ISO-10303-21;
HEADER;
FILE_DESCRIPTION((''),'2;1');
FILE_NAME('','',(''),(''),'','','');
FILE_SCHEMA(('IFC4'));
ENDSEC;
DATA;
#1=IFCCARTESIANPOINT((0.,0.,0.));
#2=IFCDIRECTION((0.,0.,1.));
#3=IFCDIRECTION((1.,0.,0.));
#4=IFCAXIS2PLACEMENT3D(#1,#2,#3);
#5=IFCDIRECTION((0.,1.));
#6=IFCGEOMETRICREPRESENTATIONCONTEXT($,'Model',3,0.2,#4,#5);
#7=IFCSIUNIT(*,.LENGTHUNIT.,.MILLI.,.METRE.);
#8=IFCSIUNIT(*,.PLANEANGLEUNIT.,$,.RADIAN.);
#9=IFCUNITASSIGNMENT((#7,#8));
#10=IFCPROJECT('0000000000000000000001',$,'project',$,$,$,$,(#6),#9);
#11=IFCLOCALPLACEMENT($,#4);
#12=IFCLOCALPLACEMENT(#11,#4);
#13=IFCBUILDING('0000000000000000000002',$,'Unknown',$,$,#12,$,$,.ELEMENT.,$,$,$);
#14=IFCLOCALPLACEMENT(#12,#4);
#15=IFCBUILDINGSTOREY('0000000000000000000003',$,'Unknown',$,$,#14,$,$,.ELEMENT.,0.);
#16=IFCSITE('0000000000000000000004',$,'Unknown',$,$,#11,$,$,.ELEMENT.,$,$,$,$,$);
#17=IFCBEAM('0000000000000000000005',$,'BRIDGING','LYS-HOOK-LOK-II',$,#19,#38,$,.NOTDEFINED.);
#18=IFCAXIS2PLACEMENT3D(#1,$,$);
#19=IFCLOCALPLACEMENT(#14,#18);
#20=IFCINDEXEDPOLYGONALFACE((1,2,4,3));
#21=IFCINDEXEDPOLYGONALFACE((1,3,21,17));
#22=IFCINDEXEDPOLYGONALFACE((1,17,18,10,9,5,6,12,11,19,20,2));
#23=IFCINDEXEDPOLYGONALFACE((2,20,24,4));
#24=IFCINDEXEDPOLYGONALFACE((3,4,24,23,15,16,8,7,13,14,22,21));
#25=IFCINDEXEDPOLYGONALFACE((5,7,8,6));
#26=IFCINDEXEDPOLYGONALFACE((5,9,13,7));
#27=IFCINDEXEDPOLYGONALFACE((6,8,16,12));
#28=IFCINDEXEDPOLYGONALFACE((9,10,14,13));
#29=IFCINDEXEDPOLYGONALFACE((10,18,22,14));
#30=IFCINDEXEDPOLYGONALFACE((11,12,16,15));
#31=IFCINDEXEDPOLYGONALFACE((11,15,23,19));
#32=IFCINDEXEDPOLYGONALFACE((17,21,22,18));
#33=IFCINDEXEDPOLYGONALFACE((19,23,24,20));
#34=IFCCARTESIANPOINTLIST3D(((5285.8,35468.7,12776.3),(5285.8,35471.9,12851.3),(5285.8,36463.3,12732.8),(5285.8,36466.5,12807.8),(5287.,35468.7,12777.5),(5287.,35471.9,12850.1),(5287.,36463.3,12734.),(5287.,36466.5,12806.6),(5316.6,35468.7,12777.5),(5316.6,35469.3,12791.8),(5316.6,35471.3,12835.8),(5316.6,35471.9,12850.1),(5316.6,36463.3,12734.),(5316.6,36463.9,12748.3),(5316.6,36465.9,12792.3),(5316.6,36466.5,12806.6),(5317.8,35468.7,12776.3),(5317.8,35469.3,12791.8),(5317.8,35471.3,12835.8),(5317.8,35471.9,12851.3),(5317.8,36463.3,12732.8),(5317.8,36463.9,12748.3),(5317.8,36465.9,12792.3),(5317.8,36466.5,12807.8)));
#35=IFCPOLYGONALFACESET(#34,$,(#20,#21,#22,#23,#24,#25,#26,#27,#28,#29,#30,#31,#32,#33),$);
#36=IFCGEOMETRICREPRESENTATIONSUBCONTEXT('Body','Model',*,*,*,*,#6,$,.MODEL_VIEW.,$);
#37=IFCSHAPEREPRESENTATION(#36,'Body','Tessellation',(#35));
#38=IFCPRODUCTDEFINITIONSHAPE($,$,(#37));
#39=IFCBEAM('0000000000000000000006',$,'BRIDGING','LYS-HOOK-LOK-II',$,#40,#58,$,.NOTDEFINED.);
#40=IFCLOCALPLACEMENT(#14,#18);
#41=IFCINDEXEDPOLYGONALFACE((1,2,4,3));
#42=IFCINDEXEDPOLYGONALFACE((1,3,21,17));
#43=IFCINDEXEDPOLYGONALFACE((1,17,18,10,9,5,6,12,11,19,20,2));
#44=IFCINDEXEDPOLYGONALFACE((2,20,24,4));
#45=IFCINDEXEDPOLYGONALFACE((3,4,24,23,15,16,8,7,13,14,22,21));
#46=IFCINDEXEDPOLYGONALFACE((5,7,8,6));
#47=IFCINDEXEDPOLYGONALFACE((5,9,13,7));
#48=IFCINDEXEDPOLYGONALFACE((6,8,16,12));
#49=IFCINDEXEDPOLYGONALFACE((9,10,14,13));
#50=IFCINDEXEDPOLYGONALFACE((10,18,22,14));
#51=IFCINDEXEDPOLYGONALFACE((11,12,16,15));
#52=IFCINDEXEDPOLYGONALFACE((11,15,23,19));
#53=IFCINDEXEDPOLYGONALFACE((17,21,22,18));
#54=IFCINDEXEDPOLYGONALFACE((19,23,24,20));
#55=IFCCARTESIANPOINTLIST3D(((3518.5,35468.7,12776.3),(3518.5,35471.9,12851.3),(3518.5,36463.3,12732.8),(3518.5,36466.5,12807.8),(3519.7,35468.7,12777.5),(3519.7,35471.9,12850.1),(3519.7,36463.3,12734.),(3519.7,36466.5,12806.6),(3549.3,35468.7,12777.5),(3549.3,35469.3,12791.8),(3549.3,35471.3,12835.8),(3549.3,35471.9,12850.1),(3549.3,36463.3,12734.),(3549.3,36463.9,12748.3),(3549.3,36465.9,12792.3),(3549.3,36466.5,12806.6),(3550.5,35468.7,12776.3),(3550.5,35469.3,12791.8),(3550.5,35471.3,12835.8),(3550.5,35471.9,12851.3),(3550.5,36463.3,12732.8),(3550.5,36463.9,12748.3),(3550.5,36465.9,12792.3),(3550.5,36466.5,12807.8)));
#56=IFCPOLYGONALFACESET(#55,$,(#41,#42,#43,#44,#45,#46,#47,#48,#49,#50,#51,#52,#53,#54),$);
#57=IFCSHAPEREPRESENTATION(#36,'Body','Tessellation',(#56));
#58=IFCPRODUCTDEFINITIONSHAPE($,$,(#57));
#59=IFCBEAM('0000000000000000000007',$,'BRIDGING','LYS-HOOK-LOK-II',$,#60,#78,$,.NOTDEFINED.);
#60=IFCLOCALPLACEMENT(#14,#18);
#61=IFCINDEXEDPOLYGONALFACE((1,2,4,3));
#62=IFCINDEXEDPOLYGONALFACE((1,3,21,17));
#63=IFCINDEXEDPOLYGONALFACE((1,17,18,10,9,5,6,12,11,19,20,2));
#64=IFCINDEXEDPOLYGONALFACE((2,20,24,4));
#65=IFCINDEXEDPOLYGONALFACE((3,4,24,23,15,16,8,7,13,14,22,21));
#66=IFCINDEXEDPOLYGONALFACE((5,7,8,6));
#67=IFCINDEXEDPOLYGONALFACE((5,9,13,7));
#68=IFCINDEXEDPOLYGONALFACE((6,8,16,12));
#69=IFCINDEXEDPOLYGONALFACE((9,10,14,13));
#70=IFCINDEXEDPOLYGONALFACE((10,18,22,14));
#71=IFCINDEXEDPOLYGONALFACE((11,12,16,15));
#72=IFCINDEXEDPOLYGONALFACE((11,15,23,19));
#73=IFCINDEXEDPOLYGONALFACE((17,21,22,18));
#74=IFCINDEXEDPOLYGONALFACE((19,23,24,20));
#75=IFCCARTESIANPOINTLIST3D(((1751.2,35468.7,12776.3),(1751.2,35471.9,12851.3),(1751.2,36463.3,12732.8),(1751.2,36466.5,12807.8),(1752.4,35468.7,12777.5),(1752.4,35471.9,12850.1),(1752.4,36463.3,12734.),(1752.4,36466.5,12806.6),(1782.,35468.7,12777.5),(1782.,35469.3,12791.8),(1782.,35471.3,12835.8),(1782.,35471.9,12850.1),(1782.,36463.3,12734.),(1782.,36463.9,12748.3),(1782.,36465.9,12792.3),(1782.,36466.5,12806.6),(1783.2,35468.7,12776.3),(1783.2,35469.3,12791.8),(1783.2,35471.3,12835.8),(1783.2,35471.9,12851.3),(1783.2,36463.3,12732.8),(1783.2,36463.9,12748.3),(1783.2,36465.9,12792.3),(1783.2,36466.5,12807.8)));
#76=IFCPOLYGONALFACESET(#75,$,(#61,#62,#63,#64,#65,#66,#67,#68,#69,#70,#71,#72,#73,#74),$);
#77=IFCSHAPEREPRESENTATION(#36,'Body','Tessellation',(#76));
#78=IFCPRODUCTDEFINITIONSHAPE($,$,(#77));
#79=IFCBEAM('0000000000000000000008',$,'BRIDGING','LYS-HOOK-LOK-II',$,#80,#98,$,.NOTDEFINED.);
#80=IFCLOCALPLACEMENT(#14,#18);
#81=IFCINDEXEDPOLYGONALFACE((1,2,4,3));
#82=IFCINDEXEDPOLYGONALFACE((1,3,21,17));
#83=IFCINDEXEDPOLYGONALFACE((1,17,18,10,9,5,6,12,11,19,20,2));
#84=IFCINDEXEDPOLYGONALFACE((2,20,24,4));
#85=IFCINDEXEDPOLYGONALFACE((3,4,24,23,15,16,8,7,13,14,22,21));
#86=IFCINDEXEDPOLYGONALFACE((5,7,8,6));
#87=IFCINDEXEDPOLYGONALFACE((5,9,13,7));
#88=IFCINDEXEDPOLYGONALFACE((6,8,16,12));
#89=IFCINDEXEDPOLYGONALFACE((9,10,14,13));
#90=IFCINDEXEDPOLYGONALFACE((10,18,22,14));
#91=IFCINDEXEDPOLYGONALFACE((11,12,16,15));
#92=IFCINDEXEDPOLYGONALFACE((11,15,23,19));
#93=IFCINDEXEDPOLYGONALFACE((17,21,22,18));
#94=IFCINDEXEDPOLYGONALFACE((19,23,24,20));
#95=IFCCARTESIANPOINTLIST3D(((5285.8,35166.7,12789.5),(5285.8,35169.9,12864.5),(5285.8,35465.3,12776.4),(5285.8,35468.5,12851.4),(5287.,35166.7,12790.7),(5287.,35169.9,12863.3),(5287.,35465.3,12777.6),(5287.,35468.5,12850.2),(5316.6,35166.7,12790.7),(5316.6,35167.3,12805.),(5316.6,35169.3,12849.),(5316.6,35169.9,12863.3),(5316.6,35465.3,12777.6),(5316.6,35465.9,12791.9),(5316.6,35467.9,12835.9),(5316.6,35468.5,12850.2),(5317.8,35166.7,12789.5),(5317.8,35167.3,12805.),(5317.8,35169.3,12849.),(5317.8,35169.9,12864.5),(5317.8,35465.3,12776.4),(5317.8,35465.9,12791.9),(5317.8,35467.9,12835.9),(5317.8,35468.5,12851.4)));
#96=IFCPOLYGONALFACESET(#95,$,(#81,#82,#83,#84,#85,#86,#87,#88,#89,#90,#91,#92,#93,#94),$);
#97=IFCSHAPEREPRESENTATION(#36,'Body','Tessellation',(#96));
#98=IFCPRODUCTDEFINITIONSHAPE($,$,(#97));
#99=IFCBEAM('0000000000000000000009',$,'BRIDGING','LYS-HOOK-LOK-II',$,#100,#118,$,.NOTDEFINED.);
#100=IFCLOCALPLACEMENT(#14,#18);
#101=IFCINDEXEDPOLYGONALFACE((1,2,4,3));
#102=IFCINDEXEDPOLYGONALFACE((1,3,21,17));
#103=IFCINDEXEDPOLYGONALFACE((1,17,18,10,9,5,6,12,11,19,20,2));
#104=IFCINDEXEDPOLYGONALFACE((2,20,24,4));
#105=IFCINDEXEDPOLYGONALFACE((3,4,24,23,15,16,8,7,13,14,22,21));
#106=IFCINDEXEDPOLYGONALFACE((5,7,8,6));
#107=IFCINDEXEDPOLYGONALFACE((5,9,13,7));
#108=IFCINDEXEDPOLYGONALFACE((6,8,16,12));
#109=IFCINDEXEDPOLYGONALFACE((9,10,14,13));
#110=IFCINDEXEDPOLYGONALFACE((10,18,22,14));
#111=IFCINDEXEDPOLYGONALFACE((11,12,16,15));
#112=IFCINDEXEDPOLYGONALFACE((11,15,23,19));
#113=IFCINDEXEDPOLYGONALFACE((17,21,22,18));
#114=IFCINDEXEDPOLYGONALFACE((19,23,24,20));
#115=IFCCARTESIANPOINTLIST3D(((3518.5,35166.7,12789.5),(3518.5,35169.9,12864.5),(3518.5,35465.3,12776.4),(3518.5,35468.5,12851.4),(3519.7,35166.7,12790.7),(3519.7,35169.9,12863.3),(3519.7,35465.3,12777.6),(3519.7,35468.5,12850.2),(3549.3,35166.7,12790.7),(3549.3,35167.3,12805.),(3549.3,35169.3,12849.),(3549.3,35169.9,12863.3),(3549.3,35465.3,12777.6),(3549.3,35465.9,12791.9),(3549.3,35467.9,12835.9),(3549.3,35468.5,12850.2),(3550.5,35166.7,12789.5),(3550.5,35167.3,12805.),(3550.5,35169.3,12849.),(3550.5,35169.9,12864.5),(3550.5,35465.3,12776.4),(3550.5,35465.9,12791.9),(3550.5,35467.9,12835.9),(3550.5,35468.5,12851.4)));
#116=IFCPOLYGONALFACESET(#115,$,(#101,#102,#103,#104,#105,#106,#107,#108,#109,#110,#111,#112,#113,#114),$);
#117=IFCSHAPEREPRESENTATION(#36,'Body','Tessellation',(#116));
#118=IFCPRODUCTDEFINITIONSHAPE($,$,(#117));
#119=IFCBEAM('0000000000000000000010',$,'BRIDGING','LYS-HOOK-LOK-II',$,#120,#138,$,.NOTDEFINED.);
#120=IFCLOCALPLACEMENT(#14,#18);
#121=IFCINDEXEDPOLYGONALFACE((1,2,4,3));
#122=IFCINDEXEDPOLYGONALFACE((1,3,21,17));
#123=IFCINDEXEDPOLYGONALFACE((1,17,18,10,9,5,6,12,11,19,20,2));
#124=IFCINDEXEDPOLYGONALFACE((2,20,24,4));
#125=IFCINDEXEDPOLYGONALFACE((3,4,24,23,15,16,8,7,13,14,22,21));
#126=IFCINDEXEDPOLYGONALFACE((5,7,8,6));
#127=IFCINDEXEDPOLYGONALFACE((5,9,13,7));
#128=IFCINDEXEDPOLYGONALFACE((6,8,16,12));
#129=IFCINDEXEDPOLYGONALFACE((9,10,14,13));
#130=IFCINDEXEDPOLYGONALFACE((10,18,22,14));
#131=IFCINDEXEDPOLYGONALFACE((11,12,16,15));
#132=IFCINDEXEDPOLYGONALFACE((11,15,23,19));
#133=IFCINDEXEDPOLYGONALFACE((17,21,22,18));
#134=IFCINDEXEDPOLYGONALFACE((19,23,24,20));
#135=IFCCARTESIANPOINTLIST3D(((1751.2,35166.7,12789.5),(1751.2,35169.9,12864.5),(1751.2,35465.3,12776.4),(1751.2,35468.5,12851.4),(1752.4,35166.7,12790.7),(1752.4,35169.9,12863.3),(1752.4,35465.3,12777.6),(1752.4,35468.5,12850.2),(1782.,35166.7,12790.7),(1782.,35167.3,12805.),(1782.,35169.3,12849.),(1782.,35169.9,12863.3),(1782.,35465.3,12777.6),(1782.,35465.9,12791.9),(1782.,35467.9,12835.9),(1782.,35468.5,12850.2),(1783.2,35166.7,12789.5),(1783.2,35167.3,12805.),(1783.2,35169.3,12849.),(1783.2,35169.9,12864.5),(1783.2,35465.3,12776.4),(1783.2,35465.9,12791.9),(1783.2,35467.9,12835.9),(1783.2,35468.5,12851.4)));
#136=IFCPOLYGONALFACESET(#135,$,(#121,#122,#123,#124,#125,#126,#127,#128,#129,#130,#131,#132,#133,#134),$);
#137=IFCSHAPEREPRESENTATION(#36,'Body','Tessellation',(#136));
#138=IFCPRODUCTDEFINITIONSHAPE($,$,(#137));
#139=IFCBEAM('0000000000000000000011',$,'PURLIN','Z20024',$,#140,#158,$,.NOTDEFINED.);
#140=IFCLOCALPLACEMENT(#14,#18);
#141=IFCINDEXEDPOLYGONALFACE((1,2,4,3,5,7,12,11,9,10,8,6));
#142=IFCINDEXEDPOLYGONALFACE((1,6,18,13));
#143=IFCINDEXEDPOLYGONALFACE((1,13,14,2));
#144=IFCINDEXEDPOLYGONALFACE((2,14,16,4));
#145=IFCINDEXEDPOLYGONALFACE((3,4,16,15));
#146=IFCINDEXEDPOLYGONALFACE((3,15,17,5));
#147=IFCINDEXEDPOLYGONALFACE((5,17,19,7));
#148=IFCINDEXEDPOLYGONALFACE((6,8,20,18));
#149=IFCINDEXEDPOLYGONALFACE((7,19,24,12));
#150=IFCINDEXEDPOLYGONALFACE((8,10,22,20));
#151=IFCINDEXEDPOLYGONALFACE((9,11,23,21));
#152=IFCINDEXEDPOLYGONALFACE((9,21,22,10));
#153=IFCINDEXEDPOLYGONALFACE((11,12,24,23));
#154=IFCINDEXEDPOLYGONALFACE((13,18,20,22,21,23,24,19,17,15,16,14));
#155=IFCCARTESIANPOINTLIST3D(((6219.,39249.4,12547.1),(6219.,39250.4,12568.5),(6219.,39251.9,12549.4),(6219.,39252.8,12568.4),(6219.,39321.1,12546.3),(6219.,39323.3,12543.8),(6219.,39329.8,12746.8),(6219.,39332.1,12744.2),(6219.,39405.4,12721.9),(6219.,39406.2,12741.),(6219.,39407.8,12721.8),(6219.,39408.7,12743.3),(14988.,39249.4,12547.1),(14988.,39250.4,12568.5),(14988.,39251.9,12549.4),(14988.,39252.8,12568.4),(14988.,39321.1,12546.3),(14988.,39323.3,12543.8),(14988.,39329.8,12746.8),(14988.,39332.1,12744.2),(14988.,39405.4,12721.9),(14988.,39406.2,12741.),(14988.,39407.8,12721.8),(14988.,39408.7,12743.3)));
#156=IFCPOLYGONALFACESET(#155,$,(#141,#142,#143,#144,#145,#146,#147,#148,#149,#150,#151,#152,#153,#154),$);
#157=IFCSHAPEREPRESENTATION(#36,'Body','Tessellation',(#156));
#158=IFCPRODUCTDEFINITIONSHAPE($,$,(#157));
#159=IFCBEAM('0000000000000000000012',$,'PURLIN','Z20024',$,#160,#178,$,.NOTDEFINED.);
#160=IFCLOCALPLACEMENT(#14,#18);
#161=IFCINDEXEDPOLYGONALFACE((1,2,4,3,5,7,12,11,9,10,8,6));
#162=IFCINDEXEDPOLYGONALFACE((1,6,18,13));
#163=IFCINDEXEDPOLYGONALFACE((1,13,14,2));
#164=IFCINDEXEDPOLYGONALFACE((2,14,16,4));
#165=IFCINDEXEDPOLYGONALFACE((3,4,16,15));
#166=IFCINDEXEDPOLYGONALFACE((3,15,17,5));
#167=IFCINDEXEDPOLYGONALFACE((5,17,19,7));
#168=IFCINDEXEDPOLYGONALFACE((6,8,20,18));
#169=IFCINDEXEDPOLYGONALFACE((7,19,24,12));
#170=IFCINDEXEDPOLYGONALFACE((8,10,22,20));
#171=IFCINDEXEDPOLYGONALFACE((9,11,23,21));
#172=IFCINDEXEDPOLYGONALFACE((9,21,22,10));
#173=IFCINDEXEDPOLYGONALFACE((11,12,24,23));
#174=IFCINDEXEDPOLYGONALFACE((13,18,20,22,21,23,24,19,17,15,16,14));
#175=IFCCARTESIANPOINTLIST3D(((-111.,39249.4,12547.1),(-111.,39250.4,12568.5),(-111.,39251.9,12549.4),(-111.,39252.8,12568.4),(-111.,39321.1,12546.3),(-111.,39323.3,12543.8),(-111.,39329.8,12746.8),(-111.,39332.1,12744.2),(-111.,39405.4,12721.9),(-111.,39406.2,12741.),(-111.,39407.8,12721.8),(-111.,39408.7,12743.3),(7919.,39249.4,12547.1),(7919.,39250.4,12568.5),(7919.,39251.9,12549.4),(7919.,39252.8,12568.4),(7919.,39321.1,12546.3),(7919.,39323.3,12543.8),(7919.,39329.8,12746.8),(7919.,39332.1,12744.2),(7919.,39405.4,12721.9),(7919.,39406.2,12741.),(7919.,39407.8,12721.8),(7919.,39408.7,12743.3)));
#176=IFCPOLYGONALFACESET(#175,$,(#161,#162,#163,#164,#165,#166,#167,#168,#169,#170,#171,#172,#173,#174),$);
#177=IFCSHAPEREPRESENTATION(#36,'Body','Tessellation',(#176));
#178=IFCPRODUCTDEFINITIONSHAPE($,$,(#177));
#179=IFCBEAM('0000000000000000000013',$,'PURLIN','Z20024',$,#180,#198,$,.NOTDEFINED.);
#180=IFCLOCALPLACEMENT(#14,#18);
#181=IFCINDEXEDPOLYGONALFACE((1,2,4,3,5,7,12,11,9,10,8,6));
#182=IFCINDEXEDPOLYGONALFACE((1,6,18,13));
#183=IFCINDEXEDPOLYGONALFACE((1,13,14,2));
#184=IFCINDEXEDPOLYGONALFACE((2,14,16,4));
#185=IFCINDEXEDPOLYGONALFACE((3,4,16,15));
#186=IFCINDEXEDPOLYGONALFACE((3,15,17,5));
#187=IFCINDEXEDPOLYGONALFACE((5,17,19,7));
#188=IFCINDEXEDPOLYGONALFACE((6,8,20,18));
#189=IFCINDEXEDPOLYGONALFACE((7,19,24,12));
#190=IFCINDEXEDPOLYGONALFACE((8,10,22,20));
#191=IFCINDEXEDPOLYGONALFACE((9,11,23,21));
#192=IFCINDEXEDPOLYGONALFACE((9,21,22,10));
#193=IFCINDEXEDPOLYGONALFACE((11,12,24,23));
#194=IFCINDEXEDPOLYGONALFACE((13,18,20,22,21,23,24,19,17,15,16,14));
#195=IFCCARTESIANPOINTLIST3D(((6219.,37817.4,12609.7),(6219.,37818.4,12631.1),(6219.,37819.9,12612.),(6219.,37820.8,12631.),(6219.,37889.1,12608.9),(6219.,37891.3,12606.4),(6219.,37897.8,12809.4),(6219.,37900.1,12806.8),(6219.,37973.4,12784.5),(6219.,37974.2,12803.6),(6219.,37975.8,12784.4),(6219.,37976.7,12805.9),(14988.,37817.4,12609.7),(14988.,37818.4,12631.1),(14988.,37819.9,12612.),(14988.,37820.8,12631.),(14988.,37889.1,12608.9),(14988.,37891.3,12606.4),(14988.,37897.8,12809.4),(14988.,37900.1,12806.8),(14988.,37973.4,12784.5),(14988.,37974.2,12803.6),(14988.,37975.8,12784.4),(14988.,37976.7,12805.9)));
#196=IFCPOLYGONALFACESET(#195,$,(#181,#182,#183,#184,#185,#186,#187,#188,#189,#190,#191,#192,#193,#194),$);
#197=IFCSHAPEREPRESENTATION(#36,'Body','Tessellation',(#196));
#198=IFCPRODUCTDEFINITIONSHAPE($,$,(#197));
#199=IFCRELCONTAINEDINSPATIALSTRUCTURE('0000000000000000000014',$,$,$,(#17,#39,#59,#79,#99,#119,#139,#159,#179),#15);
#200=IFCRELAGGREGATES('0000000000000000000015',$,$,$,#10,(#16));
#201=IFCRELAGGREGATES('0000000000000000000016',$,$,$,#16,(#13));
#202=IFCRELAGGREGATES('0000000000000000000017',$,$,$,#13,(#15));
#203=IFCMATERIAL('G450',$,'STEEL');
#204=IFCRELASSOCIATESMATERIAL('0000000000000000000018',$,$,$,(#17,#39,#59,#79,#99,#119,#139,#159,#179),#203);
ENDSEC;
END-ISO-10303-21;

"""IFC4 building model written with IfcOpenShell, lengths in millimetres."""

from ifc_helpers import new_model, si_unit, direction, frame, origin_with_axes, place, context, subcontext, project, spatial, line, indexed_curve, outline, extrude, material, element, save


model = new_model("IFC4")

# Units and contexts
model_context = context("Model", 3, precision=0.2, world=origin_with_axes(), true_north=direction((0.0, 1.0)))
body_context = subcontext(model_context, "Body", "Model", "MODEL_VIEW")
ifc_project = project(units=[si_unit("LENGTHUNIT", "METRE", prefix="MILLI"), si_unit("PLANEANGLEUNIT", "RADIAN")], contexts=[model_context])

# Site, building, storey
site_placement = place(None, origin_with_axes())
site = spatial("IfcSite", under=ifc_project, at=site_placement, Name="Unknown", CompositionType="ELEMENT")
building_placement = place(site_placement, origin_with_axes())
building = spatial("IfcBuilding", under=site, at=building_placement, Name="Unknown", CompositionType="ELEMENT")
storey_placement = place(building_placement, origin_with_axes())
storey = spatial("IfcBuildingStorey", under=building, at=storey_placement, Name="Unknown", CompositionType="ELEMENT", Elevation=0.0)

# Beams
ifc_material_1 = material(Name="G450", Category="STEEL")
for number, where, z_axis, x_axis, name in (
    (1, (5301.8, 35470.3, 12813.8), (1.0, 0.0, 0.0), (0.0, 0.999045, -0.043694), "BRIDGING"),
    (2, (3534.5, 35470.3, 12813.8), (1.0, 0.0, 0.0), (0.0, 0.999045, -0.043694), "BRIDGING"),
    (3, (1767.2, 35470.3, 12813.8), (1.0, 0.0, 0.0), (0.0, 0.999045, -0.043694), "BRIDGING"),
):
    element("IfcBeam", number, at=place(storey_placement, frame(where, z_axis=z_axis, x_axis=x_axis)), inside=storey, material=ifc_material_1, Name=name, Description="LYS-HOOK-LOK-II", PredefinedType="NOTDEFINED", context=body_context, shape_type="SolidModel", body=[
        extrude(outline(indexed_curve([(16.0, -37.5), (16.0, -22.0), (14.8, -22.0), (14.8, -36.3), (-14.8, -36.3), (-14.8, 36.3), (14.8, 36.3), (14.8, 22.0), (16.0, 22.0), (16.0, 37.5), (-16.0, 37.5), (-16.0, -37.5)], segments=[line(1, 2, 3, 4, 5, 6, 7, 8, 9, 10, 11, 12, 1)])), frame((0.0, 0.0, 0.0), z_axis=(-1.0, 0.0, 0.0), x_axis=(0.0, 0.0, 1.0)), (0.0, 0.0, -1.0), 995.6),
    ])
for number, where, z_axis, x_axis, name in (
    (4, (5301.8, 35168.3, 12827.0), (1.0, 0.0, 0.0), (0.0, 0.999039, -0.043829), "BRIDGING"),
    (5, (3534.5, 35168.3, 12827.0), (1.0, 0.0, 0.0), (0.0, 0.999039, -0.043829), "BRIDGING"),
    (6, (1767.2, 35168.3, 12827.0), (1.0, 0.0, 0.0), (0.0, 0.999039, -0.043829), "BRIDGING"),
):
    element("IfcBeam", number, at=place(storey_placement, frame(where, z_axis=z_axis, x_axis=x_axis)), inside=storey, material=ifc_material_1, Name=name, Description="LYS-HOOK-LOK-II", PredefinedType="NOTDEFINED", context=body_context, shape_type="SolidModel", body=[
        extrude(outline(indexed_curve([(16.0, -37.5), (16.0, -22.0), (14.8, -22.0), (14.8, -36.3), (-14.8, -36.3), (-14.8, 36.3), (14.8, 36.3), (14.8, 22.0), (16.0, 22.0), (16.0, 37.5), (-16.0, 37.5), (-16.0, -37.5)], segments=[line(1, 2, 3, 4, 5, 6, 7, 8, 9, 10, 11, 12, 1)])), frame((0.0, 0.0, 0.0), z_axis=(-1.0, 0.0, 0.0), x_axis=(0.0, 0.0, 1.0)), (0.0, 0.0, -1.0), 298.9),
    ])
beam_1_placement = place(storey_placement, frame((6219.0, 39326.6, 12645.3), z_axis=(0.0, -0.999048, 0.043619), x_axis=(1.0, 0.0, 0.0)))
element("IfcBeam", 7, at=beam_1_placement, inside=storey, material=ifc_material_1, Name="PURLIN", Description="Z20024", PredefinedType="NOTDEFINED", context=body_context, shape_type="SolidModel", body=[
    extrude(outline(indexed_curve([(72.8, -101.5), (72.8, -80.0), (70.4, -80.0), (70.4, -99.1), (1.2, -99.1), (1.2, 101.5), (-77.8, 101.5), (-77.8, 80.0), (-75.4, 80.0), (-75.4, 99.1), (-1.2, 99.1), (-1.2, -101.5)], segments=[line(1, 2, 3, 4, 5, 6, 7, 8, 9, 10, 11, 12, 1)])), frame((0.0, 0.0, 0.0), z_axis=(-1.0, 0.0, 0.0), x_axis=(0.0, 0.0, 1.0)), (0.0, 0.0, -1.0), 8769.0),
])
beam_2_placement = place(storey_placement, frame((-111.0, 39326.6, 12645.3), z_axis=(0.0, -0.999048, 0.043619), x_axis=(1.0, 0.0, 0.0)))
element("IfcBeam", 8, at=beam_2_placement, inside=storey, material=ifc_material_1, Name="PURLIN", Description="Z20024", PredefinedType="NOTDEFINED", context=body_context, shape_type="SolidModel", body=[
    extrude(outline(indexed_curve([(72.8, -101.5), (72.8, -80.0), (70.4, -80.0), (70.4, -99.1), (1.2, -99.1), (1.2, 101.5), (-77.8, 101.5), (-77.8, 80.0), (-75.4, 80.0), (-75.4, 99.1), (-1.2, 99.1), (-1.2, -101.5)], segments=[line(1, 2, 3, 4, 5, 6, 7, 8, 9, 10, 11, 12, 1)])), frame((0.0, 0.0, 0.0), z_axis=(-1.0, 0.0, 0.0), x_axis=(0.0, 0.0, 1.0)), (0.0, 0.0, -1.0), 8030.0),
])
beam_3_placement = place(storey_placement, frame((6219.0, 37894.6, 12707.9), z_axis=(0.0, -0.999048, 0.043619), x_axis=(1.0, 0.0, 0.0)))
element("IfcBeam", 9, at=beam_3_placement, inside=storey, material=ifc_material_1, Name="PURLIN", Description="Z20024", PredefinedType="NOTDEFINED", context=body_context, shape_type="SolidModel", body=[
    extrude(outline(indexed_curve([(72.8, -101.5), (72.8, -80.0), (70.4, -80.0), (70.4, -99.1), (1.2, -99.1), (1.2, 101.5), (-77.8, 101.5), (-77.8, 80.0), (-75.4, 80.0), (-75.4, 99.1), (-1.2, 99.1), (-1.2, -101.5)], segments=[line(1, 2, 3, 4, 5, 6, 7, 8, 9, 10, 11, 12, 1)])), frame((0.0, 0.0, 0.0), z_axis=(-1.0, 0.0, 0.0), x_axis=(0.0, 0.0, 1.0)), (0.0, 0.0, -1.0), 8769.0),
])

save(model, "model.ifc")
